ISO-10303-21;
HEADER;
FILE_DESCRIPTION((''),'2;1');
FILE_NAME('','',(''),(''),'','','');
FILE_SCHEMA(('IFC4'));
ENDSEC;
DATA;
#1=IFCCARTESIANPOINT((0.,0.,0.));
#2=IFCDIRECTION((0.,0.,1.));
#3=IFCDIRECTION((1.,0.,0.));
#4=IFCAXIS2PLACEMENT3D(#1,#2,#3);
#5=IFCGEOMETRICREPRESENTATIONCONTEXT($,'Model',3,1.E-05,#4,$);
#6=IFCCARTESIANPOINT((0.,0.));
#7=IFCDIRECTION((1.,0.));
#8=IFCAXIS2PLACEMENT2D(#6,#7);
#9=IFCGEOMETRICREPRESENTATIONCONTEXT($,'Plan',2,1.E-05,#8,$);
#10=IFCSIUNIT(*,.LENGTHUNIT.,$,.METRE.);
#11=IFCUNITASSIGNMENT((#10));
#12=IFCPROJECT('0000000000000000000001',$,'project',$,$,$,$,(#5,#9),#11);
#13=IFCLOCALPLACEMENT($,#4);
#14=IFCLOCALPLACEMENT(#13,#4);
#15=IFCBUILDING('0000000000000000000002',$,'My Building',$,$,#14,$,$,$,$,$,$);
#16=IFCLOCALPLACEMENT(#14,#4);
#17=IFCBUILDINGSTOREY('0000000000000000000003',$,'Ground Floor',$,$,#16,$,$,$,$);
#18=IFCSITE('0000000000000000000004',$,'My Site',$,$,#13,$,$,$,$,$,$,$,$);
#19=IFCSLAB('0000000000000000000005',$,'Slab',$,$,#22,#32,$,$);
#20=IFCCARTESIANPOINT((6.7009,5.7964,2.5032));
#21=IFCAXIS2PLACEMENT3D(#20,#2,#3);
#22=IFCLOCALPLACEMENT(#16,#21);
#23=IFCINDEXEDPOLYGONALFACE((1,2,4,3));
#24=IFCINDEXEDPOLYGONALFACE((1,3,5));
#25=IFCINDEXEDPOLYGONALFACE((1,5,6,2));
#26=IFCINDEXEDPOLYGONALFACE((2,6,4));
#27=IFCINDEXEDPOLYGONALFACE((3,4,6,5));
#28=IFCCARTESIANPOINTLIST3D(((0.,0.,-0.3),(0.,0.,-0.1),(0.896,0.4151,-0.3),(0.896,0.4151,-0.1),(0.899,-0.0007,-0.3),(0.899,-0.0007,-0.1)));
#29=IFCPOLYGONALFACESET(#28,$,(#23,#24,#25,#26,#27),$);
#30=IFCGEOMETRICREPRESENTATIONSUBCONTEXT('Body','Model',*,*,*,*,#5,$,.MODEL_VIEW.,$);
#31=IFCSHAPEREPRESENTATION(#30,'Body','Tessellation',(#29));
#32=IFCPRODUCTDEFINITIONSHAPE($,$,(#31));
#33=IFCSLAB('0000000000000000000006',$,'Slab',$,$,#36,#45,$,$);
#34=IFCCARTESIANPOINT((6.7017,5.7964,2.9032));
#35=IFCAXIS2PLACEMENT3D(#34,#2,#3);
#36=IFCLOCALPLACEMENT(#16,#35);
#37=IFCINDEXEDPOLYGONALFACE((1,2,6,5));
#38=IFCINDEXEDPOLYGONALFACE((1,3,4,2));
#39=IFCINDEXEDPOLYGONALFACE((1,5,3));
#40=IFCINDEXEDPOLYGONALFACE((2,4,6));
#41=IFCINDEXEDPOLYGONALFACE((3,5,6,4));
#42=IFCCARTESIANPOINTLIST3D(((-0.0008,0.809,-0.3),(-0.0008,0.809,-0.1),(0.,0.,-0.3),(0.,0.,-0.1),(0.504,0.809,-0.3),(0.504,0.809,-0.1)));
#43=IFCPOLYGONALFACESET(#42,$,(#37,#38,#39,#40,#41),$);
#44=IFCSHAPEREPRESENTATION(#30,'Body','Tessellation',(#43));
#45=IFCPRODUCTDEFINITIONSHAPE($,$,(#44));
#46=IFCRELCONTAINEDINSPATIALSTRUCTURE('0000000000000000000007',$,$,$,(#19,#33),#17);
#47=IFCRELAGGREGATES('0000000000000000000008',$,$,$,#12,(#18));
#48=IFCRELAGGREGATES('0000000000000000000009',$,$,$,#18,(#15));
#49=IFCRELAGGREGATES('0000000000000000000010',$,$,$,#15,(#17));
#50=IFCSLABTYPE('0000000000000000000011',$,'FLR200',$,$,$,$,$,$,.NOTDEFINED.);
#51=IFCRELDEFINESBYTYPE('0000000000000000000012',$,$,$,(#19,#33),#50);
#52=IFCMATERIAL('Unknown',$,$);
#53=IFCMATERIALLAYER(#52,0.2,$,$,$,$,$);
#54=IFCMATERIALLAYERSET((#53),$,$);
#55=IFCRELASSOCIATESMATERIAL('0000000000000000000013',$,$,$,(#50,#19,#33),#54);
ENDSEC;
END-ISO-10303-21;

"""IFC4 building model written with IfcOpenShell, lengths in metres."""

from ifc_helpers import new_model, si_unit, frame, origin_with_axes, origin_2d_with_axis, place, context, subcontext, project, spatial, indexed_curve, outline, extrude, material, layer, layer_set, layer_usage, type_object, element, save


model = new_model("IFC4")

# Units and contexts
model_context = context("Model", 3, precision=1e-05, world=origin_with_axes())
plan_context = context("Plan", 2, precision=1e-05, world=origin_2d_with_axis())
body_context_1 = subcontext(model_context, "Body", "Model", "MODEL_VIEW")
ifc_project = project(units=[si_unit("LENGTHUNIT", "METRE")], contexts=[model_context, plan_context])

# Site, building, storey
site_placement = place(None, origin_with_axes())
site = spatial("IfcSite", under=ifc_project, at=site_placement, Name="My Site")
building_placement = place(site_placement, origin_with_axes())
building = spatial("IfcBuilding", under=site, at=building_placement, Name="My Building")
storey_placement = place(building_placement, origin_with_axes())
storey = spatial("IfcBuildingStorey", under=building, at=storey_placement, Name="Ground Floor")

# Slabs
ifc_material = material(Name="Unknown")
ifc_layer_1 = layer(ifc_material, 0.2)
ifc_layer_set_1 = layer_set([ifc_layer_1])
ifc_layer_usage_1 = layer_usage(ifc_layer_set_1, "AXIS3", "POSITIVE", -0.3)
slab_type_1 = type_object("IfcSlabType", Name="FLR200", PredefinedType="NOTDEFINED", material=ifc_layer_set_1)
slab_1_placement = place(storey_placement, frame((6.7009, 5.7964, 2.5032), z_axis=(0.0, 0.0, 1.0), x_axis=(1.0, 0.0, 0.0)))
element("IfcSlab", 1, at=slab_1_placement, inside=storey, type_object=slab_type_1, material=ifc_layer_usage_1, Name="Slab", context=body_context_1, shape_type="SweptSolid", body=[
    extrude(outline(indexed_curve([(0.0, 0.0), (0.899, -0.0007), (0.896, 0.4151), (0.0, 0.0)])), frame((0.0, 0.0, -0.3), z_axis=(0.0, 0.0, 1.0), x_axis=(1.0, 0.0, 0.0)), (0.0, 0.0, 1.0), 0.2),
])
ifc_layer_usage_2 = layer_usage(ifc_layer_set_1, "AXIS3", "POSITIVE", -0.3)
slab_2_placement = place(storey_placement, frame((6.7017, 5.7964, 2.9032), z_axis=(0.0, 0.0, 1.0), x_axis=(1.0, 0.0, 0.0)))
element("IfcSlab", 2, at=slab_2_placement, inside=storey, type_object=slab_type_1, material=ifc_layer_usage_2, Name="Slab", context=body_context_1, shape_type="SweptSolid", body=[
    extrude(outline(indexed_curve([(0.0, 0.0), (-0.0008, 0.809), (0.504, 0.809), (0.0, 0.0)])), frame((0.0, 0.0, -0.3), z_axis=(0.0, 0.0, 1.0), x_axis=(1.0, 0.0, 0.0)), (0.0, 0.0, 1.0), 0.2),
])

save(model, "model.ifc")
